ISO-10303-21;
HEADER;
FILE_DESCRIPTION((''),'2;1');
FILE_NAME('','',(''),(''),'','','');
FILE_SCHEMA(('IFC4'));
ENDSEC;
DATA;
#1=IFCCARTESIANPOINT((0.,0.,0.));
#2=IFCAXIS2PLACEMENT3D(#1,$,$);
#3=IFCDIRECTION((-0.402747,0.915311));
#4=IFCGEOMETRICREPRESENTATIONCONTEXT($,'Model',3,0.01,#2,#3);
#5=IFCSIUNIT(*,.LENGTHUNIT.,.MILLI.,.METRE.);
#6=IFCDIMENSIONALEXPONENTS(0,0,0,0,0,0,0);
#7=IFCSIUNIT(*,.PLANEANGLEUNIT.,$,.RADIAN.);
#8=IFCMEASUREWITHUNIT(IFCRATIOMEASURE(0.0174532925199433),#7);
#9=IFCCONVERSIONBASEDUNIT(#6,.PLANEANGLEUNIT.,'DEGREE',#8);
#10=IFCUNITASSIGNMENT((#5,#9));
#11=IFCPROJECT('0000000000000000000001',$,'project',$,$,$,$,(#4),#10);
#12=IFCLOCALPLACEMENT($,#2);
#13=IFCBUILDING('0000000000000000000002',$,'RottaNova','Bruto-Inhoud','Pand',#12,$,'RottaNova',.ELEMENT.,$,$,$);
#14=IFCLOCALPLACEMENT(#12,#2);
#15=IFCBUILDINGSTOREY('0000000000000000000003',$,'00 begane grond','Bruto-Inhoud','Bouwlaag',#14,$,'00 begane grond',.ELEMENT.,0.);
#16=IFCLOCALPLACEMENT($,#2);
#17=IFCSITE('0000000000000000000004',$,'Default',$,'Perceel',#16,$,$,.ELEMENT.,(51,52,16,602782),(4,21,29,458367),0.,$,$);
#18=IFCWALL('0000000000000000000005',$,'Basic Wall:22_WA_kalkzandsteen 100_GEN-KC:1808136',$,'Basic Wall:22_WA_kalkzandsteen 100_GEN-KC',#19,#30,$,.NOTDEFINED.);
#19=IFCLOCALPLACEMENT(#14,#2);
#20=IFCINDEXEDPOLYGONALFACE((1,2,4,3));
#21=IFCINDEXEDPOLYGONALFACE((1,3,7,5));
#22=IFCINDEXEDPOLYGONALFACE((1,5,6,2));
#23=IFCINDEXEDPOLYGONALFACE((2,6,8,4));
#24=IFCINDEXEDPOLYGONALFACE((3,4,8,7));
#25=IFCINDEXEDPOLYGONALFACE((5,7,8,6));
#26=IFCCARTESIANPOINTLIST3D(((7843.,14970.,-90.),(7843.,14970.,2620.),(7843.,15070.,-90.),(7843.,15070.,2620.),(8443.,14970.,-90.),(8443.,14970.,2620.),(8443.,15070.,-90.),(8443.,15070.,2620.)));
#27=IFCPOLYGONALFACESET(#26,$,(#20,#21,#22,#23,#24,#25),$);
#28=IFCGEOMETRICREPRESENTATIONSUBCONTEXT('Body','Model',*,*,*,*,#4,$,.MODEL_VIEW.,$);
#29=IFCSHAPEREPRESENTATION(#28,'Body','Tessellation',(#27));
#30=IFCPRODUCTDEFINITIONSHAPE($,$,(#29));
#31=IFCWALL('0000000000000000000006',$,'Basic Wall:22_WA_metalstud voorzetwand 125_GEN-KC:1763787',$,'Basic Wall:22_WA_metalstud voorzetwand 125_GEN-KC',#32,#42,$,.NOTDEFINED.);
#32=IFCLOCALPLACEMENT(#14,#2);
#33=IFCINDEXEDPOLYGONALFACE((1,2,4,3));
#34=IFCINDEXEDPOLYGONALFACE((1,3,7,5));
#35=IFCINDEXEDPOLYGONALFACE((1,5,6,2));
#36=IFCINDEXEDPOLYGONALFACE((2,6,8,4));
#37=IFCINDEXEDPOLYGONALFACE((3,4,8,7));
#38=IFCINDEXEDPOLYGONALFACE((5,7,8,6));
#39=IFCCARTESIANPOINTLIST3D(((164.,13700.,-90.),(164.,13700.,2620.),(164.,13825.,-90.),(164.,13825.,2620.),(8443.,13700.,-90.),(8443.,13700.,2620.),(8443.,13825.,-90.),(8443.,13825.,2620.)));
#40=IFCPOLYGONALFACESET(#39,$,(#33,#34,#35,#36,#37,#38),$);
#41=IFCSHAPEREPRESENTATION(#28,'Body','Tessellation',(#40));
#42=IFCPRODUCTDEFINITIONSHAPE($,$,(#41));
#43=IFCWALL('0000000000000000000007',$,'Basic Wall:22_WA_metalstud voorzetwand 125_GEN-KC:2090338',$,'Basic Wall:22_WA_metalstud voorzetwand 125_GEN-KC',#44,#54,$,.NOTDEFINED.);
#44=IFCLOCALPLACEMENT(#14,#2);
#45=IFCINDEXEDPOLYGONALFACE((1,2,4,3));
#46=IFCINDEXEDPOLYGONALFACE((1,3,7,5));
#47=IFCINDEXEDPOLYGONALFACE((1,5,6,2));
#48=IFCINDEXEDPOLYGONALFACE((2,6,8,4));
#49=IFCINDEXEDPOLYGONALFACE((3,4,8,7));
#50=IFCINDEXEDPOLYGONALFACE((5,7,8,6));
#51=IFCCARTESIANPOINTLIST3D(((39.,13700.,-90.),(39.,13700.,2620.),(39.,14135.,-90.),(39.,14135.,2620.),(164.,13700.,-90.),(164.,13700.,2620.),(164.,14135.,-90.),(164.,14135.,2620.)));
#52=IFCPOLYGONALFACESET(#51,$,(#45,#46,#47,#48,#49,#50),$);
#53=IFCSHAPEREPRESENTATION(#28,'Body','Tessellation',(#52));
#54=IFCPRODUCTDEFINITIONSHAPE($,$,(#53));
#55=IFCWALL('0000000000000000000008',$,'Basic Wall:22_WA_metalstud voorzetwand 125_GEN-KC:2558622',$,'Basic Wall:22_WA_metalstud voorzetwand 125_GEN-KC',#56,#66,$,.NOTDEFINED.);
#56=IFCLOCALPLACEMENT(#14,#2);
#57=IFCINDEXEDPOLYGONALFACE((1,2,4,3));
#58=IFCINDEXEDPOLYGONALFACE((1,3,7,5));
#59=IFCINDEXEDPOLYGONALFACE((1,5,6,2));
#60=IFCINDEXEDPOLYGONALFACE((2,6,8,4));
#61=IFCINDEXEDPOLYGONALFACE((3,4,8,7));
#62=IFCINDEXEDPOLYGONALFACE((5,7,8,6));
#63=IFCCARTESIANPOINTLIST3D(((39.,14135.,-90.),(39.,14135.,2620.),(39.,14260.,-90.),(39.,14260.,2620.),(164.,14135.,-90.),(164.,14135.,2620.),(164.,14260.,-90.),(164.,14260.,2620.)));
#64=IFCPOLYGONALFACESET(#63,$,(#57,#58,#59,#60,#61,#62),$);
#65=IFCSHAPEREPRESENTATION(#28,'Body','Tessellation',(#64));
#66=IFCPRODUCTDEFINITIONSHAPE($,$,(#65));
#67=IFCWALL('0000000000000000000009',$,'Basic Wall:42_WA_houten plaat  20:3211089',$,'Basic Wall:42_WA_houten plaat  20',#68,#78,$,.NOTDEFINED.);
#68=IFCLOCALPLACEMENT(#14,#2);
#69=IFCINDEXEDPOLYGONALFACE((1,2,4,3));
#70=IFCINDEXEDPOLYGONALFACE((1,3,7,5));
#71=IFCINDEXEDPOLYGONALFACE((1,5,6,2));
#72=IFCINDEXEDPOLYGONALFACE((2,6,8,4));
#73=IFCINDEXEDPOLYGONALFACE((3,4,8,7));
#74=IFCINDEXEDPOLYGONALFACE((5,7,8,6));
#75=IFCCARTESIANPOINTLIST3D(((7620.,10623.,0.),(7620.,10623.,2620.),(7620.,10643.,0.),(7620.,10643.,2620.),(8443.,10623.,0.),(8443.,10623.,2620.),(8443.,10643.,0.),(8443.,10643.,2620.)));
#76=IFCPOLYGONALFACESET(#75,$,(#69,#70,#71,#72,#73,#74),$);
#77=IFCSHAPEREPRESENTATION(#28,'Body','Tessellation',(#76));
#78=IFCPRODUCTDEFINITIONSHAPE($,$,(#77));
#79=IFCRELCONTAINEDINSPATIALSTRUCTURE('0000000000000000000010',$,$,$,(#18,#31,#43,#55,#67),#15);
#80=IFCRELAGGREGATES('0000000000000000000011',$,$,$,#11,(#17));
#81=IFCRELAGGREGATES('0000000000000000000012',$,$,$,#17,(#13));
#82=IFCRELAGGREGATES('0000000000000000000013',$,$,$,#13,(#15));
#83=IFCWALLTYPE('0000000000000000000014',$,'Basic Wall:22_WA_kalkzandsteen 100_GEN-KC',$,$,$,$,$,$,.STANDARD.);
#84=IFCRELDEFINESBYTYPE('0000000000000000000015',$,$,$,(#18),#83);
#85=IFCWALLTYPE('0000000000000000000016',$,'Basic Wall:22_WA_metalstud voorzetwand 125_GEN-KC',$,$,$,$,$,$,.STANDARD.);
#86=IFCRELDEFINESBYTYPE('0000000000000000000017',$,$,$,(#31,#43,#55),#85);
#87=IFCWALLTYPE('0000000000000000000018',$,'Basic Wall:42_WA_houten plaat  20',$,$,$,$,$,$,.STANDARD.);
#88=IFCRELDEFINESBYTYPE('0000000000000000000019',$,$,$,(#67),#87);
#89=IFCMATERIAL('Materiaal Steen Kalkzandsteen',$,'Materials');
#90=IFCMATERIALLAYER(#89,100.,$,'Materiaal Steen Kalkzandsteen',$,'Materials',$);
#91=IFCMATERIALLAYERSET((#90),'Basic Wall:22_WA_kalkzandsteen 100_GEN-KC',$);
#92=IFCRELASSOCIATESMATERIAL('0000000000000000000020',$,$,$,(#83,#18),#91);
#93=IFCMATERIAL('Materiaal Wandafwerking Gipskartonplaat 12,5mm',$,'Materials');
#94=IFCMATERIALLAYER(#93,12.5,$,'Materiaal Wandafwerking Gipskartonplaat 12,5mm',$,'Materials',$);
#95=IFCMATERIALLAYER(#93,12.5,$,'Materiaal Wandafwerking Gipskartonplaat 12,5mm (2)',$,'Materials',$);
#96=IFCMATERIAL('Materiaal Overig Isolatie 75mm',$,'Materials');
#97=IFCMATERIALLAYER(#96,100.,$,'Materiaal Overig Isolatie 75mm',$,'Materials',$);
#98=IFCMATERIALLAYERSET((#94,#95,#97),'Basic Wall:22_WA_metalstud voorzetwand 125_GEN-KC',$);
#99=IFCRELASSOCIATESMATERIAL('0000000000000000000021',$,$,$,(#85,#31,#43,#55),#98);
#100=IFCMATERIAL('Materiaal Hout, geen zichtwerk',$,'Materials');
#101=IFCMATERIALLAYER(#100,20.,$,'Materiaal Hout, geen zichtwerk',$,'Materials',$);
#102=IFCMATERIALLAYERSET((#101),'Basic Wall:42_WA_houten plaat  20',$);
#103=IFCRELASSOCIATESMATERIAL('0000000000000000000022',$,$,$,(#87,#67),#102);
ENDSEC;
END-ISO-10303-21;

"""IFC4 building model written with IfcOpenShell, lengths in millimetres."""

from ifc_helpers import new_model, entity, si_unit, converted_unit, direction, frame, frame_2d, origin, place, context, subcontext, project, spatial, rectangle, extrude, material, layer, layer_set, type_object, element, save


model = new_model("IFC4")

# Units and contexts
model_context = context("Model", 3, precision=0.01, world=origin(), true_north=direction((-0.402747, 0.915311)))
body_context = subcontext(model_context, "Body", "Model", "MODEL_VIEW")
ifc_project = project(units=[si_unit("LENGTHUNIT", "METRE", prefix="MILLI"), converted_unit("PLANEANGLEUNIT", "DEGREE", entity("IfcRatioMeasure", 0.0174532925199433), si_unit("PLANEANGLEUNIT", "RADIAN"), dimensions=[0, 0, 0, 0, 0, 0, 0])], contexts=[model_context])

# Site, building, storey
site_placement = place(None, origin())
site = spatial("IfcSite", under=ifc_project, at=site_placement, Name="Default", ObjectType="Perceel", CompositionType="ELEMENT", RefLatitude=(51, 52, 16, 602782), RefLongitude=(4, 21, 29, 458367), RefElevation=0.0)
building_placement = place(None, origin())
building = spatial("IfcBuilding", under=site, at=building_placement, Name="RottaNova", Description="Bruto-Inhoud", ObjectType="Pand", LongName="RottaNova", CompositionType="ELEMENT")
storey_placement = place(building_placement, origin())
storey = spatial("IfcBuildingStorey", under=building, at=storey_placement, Name="00 begane grond", Description="Bruto-Inhoud", ObjectType="Bouwlaag", LongName="00 begane grond", CompositionType="ELEMENT", Elevation=0.0)

# Walls
ifc_material_1 = material(Name="Materiaal Steen Kalkzandsteen", Category="Materials")
ifc_layer_1 = layer(ifc_material_1, 100.0, Name="Materiaal Steen Kalkzandsteen", Category="Materials")
ifc_layer_set_1 = layer_set([ifc_layer_1], Name="Basic Wall:22_WA_kalkzandsteen 100_GEN-KC")
wall_type_1 = type_object("IfcWallType", Name="Basic Wall:22_WA_kalkzandsteen 100_GEN-KC", PredefinedType="STANDARD", material=ifc_layer_set_1)
wall_1_placement = place(storey_placement, frame((8443.0, 15020.0, -90.0), z_axis=(0.0, 0.0, 1.0), x_axis=(-1.0, 0.0, 0.0)))
element("IfcWall", 1, at=wall_1_placement, inside=storey, type_object=wall_type_1, material=ifc_layer_set_1, Name="Basic Wall:22_WA_kalkzandsteen 100_GEN-KC:1808136", ObjectType="Basic Wall:22_WA_kalkzandsteen 100_GEN-KC", PredefinedType="NOTDEFINED", context=body_context, shape_type="SweptSolid", body=[
    extrude(rectangle(XDim=600.0, YDim=100.0, at=frame_2d((300.0, 0.0), x_axis=(-1.0, 0.0))), origin(), (0.0, 0.0, 1.0), 2710.0),
])
ifc_material_2 = material(Name="Materiaal Wandafwerking Gipskartonplaat 12,5mm", Category="Materials")
ifc_layer_2 = layer(ifc_material_2, 12.5, Name="Materiaal Wandafwerking Gipskartonplaat 12,5mm", Category="Materials")
ifc_layer_3 = layer(ifc_material_2, 12.5, Name="Materiaal Wandafwerking Gipskartonplaat 12,5mm (2)", Category="Materials")
ifc_material_3 = material(Name="Materiaal Overig Isolatie 75mm", Category="Materials")
ifc_layer_4 = layer(ifc_material_3, 100.0, Name="Materiaal Overig Isolatie 75mm", Category="Materials")
ifc_layer_set_2 = layer_set([ifc_layer_2, ifc_layer_3, ifc_layer_4], Name="Basic Wall:22_WA_metalstud voorzetwand 125_GEN-KC")
wall_type_2 = type_object("IfcWallType", Name="Basic Wall:22_WA_metalstud voorzetwand 125_GEN-KC", PredefinedType="STANDARD", material=ifc_layer_set_2)
wall_2_placement = place(storey_placement, frame((164.0, 13762.5, -90.0)))
element("IfcWall", 2, at=wall_2_placement, inside=storey, type_object=wall_type_2, material=ifc_layer_set_2, Name="Basic Wall:22_WA_metalstud voorzetwand 125_GEN-KC:1763787", ObjectType="Basic Wall:22_WA_metalstud voorzetwand 125_GEN-KC", PredefinedType="NOTDEFINED", context=body_context, shape_type="SweptSolid", body=[
    extrude(rectangle(XDim=8279.0, YDim=125.0, at=frame_2d((4139.5, 0.0), x_axis=(-1.0, 0.0))), origin(), (0.0, 0.0, 1.0), 2710.0),
])
wall_3_placement = place(storey_placement, frame((101.5, 13700.0, -90.0), z_axis=(0.0, 0.0, 1.0), x_axis=(0.0, 1.0, 0.0)))
element("IfcWall", 3, at=wall_3_placement, inside=storey, type_object=wall_type_2, material=ifc_layer_set_2, Name="Basic Wall:22_WA_metalstud voorzetwand 125_GEN-KC:2090338", ObjectType="Basic Wall:22_WA_metalstud voorzetwand 125_GEN-KC", PredefinedType="NOTDEFINED", context=body_context, shape_type="SweptSolid", body=[
    extrude(rectangle(XDim=435.0, YDim=125.0, at=frame_2d((217.5, 0.0), x_axis=(-1.0, 0.0))), origin(), (0.0, 0.0, 1.0), 2710.0),
])
wall_4_placement = place(storey_placement, frame((164.0, 14197.5, -90.0), z_axis=(0.0, 0.0, 1.0), x_axis=(-1.0, 0.0, 0.0)))
element("IfcWall", 4, at=wall_4_placement, inside=storey, type_object=wall_type_2, material=ifc_layer_set_2, Name="Basic Wall:22_WA_metalstud voorzetwand 125_GEN-KC:2558622", ObjectType="Basic Wall:22_WA_metalstud voorzetwand 125_GEN-KC", PredefinedType="NOTDEFINED", context=body_context, shape_type="SweptSolid", body=[
    extrude(rectangle(XDim=125.0, YDim=125.0, at=frame_2d((62.5, 0.0), x_axis=(-1.0, 0.0))), origin(), (0.0, 0.0, 1.0), 2710.0),
])
ifc_material_4 = material(Name="Materiaal Hout, geen zichtwerk", Category="Materials")
ifc_layer_5 = layer(ifc_material_4, 20.0, Name="Materiaal Hout, geen zichtwerk", Category="Materials")
ifc_layer_set_3 = layer_set([ifc_layer_5], Name="Basic Wall:42_WA_houten plaat  20")
wall_type_3 = type_object("IfcWallType", Name="Basic Wall:42_WA_houten plaat  20", PredefinedType="STANDARD", material=ifc_layer_set_3)
wall_5_placement = place(storey_placement, frame((7620.0, 10633.0, 0.0)))
element("IfcWall", 5, at=wall_5_placement, inside=storey, type_object=wall_type_3, material=ifc_layer_set_3, Name="Basic Wall:42_WA_houten plaat  20:3211089", ObjectType="Basic Wall:42_WA_houten plaat  20", PredefinedType="NOTDEFINED", context=body_context, shape_type="SweptSolid", body=[
    extrude(rectangle(XDim=823.0, YDim=20.0, at=frame_2d((411.5, 0.0), x_axis=(-1.0, 0.0))), origin(), (0.0, 0.0, 1.0), 2620.0),
])

save(model, "model.ifc")
